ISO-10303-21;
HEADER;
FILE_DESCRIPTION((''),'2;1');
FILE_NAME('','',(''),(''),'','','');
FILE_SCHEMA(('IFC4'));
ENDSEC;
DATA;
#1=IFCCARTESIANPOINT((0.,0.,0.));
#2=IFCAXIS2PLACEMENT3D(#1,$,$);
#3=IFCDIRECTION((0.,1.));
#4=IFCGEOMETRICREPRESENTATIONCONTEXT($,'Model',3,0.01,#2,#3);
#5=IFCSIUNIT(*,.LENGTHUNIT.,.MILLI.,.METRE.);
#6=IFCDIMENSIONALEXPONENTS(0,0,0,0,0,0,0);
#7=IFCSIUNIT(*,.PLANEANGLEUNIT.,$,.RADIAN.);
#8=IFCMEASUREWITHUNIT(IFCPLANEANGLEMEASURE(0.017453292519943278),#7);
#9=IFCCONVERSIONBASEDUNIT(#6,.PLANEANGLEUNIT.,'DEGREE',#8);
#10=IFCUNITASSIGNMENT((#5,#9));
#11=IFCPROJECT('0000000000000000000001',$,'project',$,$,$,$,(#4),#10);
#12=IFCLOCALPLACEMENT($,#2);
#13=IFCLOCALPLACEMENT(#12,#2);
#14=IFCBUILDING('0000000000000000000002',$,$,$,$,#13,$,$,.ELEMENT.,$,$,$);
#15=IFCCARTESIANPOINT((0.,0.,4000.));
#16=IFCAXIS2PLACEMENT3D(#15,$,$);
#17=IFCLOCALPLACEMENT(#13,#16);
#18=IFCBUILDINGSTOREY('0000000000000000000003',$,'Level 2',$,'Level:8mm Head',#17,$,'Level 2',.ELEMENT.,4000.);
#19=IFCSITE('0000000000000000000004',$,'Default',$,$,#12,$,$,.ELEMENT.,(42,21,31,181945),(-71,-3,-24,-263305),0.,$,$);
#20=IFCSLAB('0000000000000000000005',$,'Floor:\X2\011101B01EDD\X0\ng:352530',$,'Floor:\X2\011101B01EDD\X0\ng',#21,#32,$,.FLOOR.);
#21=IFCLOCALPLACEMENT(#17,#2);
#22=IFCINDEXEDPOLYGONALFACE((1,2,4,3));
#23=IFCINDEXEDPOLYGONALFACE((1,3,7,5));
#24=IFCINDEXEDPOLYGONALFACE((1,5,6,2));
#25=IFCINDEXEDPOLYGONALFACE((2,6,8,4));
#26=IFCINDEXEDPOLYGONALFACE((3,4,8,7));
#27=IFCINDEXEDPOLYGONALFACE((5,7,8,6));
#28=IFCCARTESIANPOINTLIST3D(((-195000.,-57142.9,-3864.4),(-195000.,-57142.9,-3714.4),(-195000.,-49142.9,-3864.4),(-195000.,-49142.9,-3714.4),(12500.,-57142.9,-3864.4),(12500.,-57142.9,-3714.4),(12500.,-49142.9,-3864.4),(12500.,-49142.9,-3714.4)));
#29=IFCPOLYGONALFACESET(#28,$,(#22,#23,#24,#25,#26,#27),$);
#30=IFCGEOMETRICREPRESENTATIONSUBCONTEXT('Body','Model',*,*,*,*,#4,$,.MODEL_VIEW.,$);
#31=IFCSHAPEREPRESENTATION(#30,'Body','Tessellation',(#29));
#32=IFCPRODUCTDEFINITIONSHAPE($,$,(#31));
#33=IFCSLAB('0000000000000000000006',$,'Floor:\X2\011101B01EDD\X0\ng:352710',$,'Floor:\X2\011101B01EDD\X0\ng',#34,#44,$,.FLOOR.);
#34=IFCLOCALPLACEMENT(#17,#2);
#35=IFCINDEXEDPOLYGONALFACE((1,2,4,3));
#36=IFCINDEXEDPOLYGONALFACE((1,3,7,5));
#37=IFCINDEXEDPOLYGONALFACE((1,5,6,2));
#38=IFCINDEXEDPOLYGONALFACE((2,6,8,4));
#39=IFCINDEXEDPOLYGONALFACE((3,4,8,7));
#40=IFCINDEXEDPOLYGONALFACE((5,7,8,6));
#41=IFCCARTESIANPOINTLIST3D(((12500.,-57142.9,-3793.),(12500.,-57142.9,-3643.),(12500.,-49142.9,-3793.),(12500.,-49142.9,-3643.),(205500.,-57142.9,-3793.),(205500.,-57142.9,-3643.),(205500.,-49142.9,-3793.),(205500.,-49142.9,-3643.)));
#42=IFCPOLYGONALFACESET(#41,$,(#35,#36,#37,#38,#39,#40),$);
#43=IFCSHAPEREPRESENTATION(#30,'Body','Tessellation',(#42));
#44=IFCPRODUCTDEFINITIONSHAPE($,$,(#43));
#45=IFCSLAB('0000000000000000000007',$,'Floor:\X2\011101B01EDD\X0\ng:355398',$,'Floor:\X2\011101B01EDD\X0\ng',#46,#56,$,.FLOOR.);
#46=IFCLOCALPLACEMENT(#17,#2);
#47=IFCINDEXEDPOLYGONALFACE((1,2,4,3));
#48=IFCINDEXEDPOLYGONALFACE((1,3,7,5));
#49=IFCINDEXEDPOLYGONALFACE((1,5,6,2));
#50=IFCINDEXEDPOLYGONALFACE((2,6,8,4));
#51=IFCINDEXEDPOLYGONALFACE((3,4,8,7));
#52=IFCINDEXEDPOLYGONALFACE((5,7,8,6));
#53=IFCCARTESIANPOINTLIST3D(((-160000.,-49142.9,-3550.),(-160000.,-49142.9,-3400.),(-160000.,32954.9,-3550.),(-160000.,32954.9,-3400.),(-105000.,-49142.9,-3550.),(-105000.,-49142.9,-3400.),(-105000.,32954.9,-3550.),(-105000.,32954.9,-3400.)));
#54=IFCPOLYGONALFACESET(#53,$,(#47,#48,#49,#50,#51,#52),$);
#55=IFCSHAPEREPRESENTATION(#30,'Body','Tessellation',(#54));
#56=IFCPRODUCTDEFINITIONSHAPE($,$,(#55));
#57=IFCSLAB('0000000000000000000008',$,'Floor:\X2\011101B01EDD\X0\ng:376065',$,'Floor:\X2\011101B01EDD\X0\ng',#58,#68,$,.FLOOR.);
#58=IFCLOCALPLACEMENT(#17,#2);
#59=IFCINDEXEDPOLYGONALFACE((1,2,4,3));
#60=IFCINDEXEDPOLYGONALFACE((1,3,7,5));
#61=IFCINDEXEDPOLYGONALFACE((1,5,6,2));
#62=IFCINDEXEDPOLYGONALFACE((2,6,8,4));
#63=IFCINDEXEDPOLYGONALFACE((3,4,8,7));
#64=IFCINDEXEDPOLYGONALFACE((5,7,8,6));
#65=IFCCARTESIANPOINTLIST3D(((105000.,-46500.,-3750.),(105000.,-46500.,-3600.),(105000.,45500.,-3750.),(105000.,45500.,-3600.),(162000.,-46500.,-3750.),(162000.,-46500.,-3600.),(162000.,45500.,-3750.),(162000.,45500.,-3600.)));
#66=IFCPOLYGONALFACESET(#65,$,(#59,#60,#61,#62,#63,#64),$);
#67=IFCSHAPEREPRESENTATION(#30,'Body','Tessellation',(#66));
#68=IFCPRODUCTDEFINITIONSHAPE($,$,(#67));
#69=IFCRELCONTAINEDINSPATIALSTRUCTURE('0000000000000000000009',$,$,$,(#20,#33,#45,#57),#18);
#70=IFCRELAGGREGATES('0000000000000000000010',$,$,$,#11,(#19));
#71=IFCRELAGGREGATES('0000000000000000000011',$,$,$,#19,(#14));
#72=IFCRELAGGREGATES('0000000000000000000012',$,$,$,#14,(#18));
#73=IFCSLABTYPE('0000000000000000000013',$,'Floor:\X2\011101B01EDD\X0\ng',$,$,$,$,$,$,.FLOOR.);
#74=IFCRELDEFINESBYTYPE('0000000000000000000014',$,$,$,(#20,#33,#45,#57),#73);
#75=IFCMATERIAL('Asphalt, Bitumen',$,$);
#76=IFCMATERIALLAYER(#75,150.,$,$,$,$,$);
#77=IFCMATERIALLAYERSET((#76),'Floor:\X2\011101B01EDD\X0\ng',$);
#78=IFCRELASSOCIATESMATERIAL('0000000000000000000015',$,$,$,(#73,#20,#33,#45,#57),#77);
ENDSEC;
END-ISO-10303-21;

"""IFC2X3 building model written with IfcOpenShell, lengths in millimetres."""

from ifc_helpers import new_model, entity, si_unit, converted_unit, direction, frame, frame_2d, origin, origin_2d_with_axis, place, context, subcontext, project, spatial, rectangle, extrude, material, layer, layer_set, layer_usage, type_object, element, save


model = new_model("IFC2X3")

# Units and contexts
model_context = context("Model", 3, precision=0.01, world=origin(), true_north=direction((0.0, 1.0)))
body_context = subcontext(model_context, "Body", "Model", "MODEL_VIEW")
ifc_project = project(units=[si_unit("LENGTHUNIT", "METRE", prefix="MILLI"), converted_unit("PLANEANGLEUNIT", "DEGREE", entity("IfcPlaneAngleMeasure", 0.017453292519943278), si_unit("PLANEANGLEUNIT", "RADIAN"), dimensions=[0, 0, 0, 0, 0, 0, 0])], contexts=[model_context])

# Site, building, storey
site_placement = place(None, origin())
site = spatial("IfcSite", under=ifc_project, at=site_placement, Name="Default", CompositionType="ELEMENT", RefLatitude=(42, 21, 31, 181945), RefLongitude=(-71, -3, -24, -263305), RefElevation=0.0)
building_placement = place(site_placement, origin())
building = spatial("IfcBuilding", under=site, at=building_placement, CompositionType="ELEMENT")
storey_placement = place(building_placement, frame((0.0, 0.0, 4000.0)))
storey = spatial("IfcBuildingStorey", under=building, at=storey_placement, Name="Level 2", ObjectType="Level:8mm Head", LongName="Level 2", CompositionType="ELEMENT", Elevation=4000.0)

# Slabs
ifc_material_1 = material(Name="Asphalt, Bitumen")
ifc_layer_1 = layer(ifc_material_1, 150.0)
ifc_layer_set_1 = layer_set([ifc_layer_1], Name="Floor:đường")
ifc_layer_usage_1 = layer_usage(ifc_layer_set_1, "AXIS3", "POSITIVE", 0.0)
slab_type_1 = type_object("IfcSlabType", Name="Floor:đường", PredefinedType="FLOOR", material=ifc_layer_set_1)
slab_1_placement = place(storey_placement, origin())
element("IfcSlab", 1, at=slab_1_placement, inside=storey, type_object=slab_type_1, material=ifc_layer_usage_1, Name="Floor:đường:352530", ObjectType="Floor:đường", PredefinedType="FLOOR", context=body_context, shape_type="SweptSolid", body=[
    extrude(rectangle(XDim=8000.0, YDim=207500.0, at=origin_2d_with_axis()), frame((-91250.0, -53142.9, -3714.4), z_axis=(0.0, 0.0, -1.0), x_axis=(0.0, 1.0, 0.0)), (0.0, 0.0, 1.0), 150.0),
])
ifc_layer_usage_2 = layer_usage(ifc_layer_set_1, "AXIS3", "POSITIVE", 0.0)
slab_2_placement = place(storey_placement, origin())
element("IfcSlab", 2, at=slab_2_placement, inside=storey, type_object=slab_type_1, material=ifc_layer_usage_2, Name="Floor:đường:352710", ObjectType="Floor:đường", PredefinedType="FLOOR", context=body_context, shape_type="SweptSolid", body=[
    extrude(rectangle(XDim=8000.0, YDim=193000.0, at=origin_2d_with_axis()), frame((109000.0, -53142.9, -3643.0), z_axis=(0.0, 0.0, -1.0), x_axis=(0.0, 1.0, 0.0)), (0.0, 0.0, 1.0), 150.0),
])
ifc_layer_usage_3 = layer_usage(ifc_layer_set_1, "AXIS3", "POSITIVE", 0.0)
slab_3_placement = place(storey_placement, origin())
element("IfcSlab", 3, at=slab_3_placement, inside=storey, type_object=slab_type_1, material=ifc_layer_usage_3, Name="Floor:đường:355398", ObjectType="Floor:đường", PredefinedType="FLOOR", context=body_context, shape_type="SweptSolid", body=[
    extrude(rectangle(XDim=82097.8, YDim=55000.0, at=frame_2d((0.0, 0.0), x_axis=(1.0, 0.0))), frame((-132500.0, -8094.0, -3400.0), z_axis=(0.0, 0.0, -1.0), x_axis=(0.0, 1.0, 0.0)), (0.0, 0.0, 1.0), 150.0),
])
ifc_layer_usage_4 = layer_usage(ifc_layer_set_1, "AXIS3", "POSITIVE", 0.0)
slab_4_placement = place(storey_placement, origin())
element("IfcSlab", 4, at=slab_4_placement, inside=storey, type_object=slab_type_1, material=ifc_layer_usage_4, Name="Floor:đường:376065", ObjectType="Floor:đường", PredefinedType="FLOOR", context=body_context, shape_type="SweptSolid", body=[
    extrude(rectangle(XDim=92000.0, YDim=57000.0, at=frame_2d((0.0, 0.0), x_axis=(1.0, 0.0))), frame((133500.0, -500.0, -3600.0), z_axis=(0.0, 0.0, -1.0), x_axis=(0.0, 1.0, 0.0)), (0.0, 0.0, 1.0), 150.0),
])

save(model, "model.ifc")
